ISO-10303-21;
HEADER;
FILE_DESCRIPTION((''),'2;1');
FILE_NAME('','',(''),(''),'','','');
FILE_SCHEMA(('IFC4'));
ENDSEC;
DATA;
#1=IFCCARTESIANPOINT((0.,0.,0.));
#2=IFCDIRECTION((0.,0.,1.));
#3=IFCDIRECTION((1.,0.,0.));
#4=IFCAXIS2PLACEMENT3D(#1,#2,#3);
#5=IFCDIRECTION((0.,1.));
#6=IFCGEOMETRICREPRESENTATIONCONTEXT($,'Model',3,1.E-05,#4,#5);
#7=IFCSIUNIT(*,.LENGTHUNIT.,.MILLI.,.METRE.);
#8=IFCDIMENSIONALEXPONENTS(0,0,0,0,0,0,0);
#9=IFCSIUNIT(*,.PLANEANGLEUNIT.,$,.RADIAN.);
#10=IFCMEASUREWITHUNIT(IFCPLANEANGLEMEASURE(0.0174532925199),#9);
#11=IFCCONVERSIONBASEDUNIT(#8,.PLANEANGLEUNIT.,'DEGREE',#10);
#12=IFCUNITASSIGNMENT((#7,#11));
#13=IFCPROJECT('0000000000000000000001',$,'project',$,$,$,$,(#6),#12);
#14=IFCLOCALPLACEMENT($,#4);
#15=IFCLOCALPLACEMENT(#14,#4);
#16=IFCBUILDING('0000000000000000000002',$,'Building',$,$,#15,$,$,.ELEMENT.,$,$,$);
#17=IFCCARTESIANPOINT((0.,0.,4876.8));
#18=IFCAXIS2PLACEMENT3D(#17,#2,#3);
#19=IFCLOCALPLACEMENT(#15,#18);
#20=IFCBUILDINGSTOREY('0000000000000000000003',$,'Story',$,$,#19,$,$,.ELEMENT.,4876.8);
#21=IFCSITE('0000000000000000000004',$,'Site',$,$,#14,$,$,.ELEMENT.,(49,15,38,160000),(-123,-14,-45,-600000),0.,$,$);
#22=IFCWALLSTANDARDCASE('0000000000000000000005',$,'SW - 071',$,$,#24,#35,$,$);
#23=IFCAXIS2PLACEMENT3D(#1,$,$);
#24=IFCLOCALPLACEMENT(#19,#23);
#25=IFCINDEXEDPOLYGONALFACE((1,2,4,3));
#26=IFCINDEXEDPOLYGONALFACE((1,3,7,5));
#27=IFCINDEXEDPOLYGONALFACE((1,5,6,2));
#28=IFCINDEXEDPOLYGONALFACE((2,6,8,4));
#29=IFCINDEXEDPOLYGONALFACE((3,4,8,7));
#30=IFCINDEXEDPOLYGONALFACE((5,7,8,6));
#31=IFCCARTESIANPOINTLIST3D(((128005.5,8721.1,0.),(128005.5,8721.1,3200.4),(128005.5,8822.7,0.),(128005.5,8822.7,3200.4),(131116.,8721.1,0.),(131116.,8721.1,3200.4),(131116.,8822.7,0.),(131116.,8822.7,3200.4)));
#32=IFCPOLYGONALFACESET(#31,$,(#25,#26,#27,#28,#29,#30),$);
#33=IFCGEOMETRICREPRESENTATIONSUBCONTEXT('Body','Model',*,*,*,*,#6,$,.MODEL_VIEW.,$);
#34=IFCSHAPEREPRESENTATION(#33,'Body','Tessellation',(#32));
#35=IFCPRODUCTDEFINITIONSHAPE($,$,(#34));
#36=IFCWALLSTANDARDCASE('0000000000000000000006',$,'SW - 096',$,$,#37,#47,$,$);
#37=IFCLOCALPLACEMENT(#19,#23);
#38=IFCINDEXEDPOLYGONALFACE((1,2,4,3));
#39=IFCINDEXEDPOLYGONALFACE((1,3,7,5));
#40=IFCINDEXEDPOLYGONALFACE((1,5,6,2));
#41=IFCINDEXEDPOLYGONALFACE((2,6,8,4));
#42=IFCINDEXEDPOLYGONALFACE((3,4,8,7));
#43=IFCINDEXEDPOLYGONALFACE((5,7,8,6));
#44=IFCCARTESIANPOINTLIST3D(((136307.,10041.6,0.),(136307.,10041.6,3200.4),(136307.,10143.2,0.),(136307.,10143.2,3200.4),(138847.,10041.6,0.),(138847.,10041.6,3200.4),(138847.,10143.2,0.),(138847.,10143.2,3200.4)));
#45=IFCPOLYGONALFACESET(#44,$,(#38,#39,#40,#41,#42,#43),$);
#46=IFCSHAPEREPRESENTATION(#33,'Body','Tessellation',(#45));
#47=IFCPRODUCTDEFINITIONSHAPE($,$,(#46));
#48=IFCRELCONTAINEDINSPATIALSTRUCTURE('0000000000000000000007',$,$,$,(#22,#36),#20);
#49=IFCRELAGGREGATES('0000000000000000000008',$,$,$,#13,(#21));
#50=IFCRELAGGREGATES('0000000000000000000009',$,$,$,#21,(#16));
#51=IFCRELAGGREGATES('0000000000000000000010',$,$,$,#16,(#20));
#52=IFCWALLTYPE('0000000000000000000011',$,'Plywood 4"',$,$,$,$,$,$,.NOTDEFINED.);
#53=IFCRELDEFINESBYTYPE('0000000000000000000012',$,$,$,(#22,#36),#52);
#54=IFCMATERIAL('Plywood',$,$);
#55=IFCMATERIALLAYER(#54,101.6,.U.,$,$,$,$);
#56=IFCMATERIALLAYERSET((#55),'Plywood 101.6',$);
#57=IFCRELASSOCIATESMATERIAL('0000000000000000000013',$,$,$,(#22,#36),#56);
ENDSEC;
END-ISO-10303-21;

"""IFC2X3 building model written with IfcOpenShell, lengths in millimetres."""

from ifc_helpers import new_model, entity, si_unit, converted_unit, direction, frame, origin_with_axes, place, context, subcontext, project, spatial, polyline, outline, extrude, material, layer, layer_set, layer_usage, type_object, element, save


model = new_model("IFC2X3")

# Units and contexts
model_context = context("Model", 3, precision=1e-05, world=origin_with_axes(), true_north=direction((0.0, 1.0)))
body_context = subcontext(model_context, "Body", "Model", "MODEL_VIEW")
ifc_project = project(units=[si_unit("LENGTHUNIT", "METRE", prefix="MILLI"), converted_unit("PLANEANGLEUNIT", "DEGREE", entity("IfcPlaneAngleMeasure", 0.0174532925199), si_unit("PLANEANGLEUNIT", "RADIAN"), dimensions=[0, 0, 0, 0, 0, 0, 0])], contexts=[model_context])

# Site, building, storey
site_placement = place(None, origin_with_axes())
site = spatial("IfcSite", under=ifc_project, at=site_placement, Name="Site", CompositionType="ELEMENT", RefLatitude=(49, 15, 38, 160000), RefLongitude=(-123, -14, -45, -600000), RefElevation=0.0)
building_placement = place(site_placement, origin_with_axes())
building = spatial("IfcBuilding", under=site, at=building_placement, Name="Building", CompositionType="ELEMENT")
storey_placement = place(building_placement, frame((0.0, 0.0, 4876.8), z_axis=(0.0, 0.0, 1.0), x_axis=(1.0, 0.0, 0.0)))
storey = spatial("IfcBuildingStorey", under=building, at=storey_placement, Name="Story", CompositionType="ELEMENT", Elevation=4876.8)

# Shared definitions
ifc_material_1 = material(Name="Plywood")

# Walls
ifc_layer_1 = layer(ifc_material_1, 101.6, ventilated="UNKNOWN")
ifc_layer_set_1 = layer_set([ifc_layer_1], Name="Plywood 101.6")
ifc_layer_usage_1 = layer_usage(ifc_layer_set_1, "AXIS2", "NEGATIVE", 0.0)
wall_type_1 = type_object("IfcWallType", Name="Plywood 4\"", PredefinedType="NOTDEFINED")
wall_1_placement = place(storey_placement, frame((131116.0, 8721.1, 0.0), z_axis=(0.0, 0.0, 1.0), x_axis=(-1.0, 0.0, 0.0)))
element("IfcWallStandardCase", 1, at=wall_1_placement, inside=storey, type_object=wall_type_1, material=ifc_layer_usage_1, Name="SW - 071", context=body_context, shape_type="SweptSolid", body=[
    extrude(outline(polyline([(0.0, -101.6), (3110.6, -101.6), (3110.6, 0.0), (0.0, 0.0), (0.0, -101.6)])), origin_with_axes(), (0.0, 0.0, 1.0), 3200.4),
])
ifc_layer_usage_2 = layer_usage(ifc_layer_set_1, "AXIS2", "POSITIVE", 0.0)
wall_2_placement = place(storey_placement, frame((136307.0, 10041.6, 0.0), z_axis=(0.0, 0.0, 1.0), x_axis=(1.0, 0.0, 0.0)))
element("IfcWallStandardCase", 2, at=wall_2_placement, inside=storey, type_object=wall_type_1, material=ifc_layer_usage_2, Name="SW - 096", context=body_context, shape_type="SweptSolid", body=[
    extrude(outline(polyline([(0.0, 0.0), (2540.0, 0.0), (2540.0, 101.6), (0.0, 101.6), (0.0, 0.0)])), origin_with_axes(), (0.0, 0.0, 1.0), 3200.4),
])

save(model, "model.ifc")
